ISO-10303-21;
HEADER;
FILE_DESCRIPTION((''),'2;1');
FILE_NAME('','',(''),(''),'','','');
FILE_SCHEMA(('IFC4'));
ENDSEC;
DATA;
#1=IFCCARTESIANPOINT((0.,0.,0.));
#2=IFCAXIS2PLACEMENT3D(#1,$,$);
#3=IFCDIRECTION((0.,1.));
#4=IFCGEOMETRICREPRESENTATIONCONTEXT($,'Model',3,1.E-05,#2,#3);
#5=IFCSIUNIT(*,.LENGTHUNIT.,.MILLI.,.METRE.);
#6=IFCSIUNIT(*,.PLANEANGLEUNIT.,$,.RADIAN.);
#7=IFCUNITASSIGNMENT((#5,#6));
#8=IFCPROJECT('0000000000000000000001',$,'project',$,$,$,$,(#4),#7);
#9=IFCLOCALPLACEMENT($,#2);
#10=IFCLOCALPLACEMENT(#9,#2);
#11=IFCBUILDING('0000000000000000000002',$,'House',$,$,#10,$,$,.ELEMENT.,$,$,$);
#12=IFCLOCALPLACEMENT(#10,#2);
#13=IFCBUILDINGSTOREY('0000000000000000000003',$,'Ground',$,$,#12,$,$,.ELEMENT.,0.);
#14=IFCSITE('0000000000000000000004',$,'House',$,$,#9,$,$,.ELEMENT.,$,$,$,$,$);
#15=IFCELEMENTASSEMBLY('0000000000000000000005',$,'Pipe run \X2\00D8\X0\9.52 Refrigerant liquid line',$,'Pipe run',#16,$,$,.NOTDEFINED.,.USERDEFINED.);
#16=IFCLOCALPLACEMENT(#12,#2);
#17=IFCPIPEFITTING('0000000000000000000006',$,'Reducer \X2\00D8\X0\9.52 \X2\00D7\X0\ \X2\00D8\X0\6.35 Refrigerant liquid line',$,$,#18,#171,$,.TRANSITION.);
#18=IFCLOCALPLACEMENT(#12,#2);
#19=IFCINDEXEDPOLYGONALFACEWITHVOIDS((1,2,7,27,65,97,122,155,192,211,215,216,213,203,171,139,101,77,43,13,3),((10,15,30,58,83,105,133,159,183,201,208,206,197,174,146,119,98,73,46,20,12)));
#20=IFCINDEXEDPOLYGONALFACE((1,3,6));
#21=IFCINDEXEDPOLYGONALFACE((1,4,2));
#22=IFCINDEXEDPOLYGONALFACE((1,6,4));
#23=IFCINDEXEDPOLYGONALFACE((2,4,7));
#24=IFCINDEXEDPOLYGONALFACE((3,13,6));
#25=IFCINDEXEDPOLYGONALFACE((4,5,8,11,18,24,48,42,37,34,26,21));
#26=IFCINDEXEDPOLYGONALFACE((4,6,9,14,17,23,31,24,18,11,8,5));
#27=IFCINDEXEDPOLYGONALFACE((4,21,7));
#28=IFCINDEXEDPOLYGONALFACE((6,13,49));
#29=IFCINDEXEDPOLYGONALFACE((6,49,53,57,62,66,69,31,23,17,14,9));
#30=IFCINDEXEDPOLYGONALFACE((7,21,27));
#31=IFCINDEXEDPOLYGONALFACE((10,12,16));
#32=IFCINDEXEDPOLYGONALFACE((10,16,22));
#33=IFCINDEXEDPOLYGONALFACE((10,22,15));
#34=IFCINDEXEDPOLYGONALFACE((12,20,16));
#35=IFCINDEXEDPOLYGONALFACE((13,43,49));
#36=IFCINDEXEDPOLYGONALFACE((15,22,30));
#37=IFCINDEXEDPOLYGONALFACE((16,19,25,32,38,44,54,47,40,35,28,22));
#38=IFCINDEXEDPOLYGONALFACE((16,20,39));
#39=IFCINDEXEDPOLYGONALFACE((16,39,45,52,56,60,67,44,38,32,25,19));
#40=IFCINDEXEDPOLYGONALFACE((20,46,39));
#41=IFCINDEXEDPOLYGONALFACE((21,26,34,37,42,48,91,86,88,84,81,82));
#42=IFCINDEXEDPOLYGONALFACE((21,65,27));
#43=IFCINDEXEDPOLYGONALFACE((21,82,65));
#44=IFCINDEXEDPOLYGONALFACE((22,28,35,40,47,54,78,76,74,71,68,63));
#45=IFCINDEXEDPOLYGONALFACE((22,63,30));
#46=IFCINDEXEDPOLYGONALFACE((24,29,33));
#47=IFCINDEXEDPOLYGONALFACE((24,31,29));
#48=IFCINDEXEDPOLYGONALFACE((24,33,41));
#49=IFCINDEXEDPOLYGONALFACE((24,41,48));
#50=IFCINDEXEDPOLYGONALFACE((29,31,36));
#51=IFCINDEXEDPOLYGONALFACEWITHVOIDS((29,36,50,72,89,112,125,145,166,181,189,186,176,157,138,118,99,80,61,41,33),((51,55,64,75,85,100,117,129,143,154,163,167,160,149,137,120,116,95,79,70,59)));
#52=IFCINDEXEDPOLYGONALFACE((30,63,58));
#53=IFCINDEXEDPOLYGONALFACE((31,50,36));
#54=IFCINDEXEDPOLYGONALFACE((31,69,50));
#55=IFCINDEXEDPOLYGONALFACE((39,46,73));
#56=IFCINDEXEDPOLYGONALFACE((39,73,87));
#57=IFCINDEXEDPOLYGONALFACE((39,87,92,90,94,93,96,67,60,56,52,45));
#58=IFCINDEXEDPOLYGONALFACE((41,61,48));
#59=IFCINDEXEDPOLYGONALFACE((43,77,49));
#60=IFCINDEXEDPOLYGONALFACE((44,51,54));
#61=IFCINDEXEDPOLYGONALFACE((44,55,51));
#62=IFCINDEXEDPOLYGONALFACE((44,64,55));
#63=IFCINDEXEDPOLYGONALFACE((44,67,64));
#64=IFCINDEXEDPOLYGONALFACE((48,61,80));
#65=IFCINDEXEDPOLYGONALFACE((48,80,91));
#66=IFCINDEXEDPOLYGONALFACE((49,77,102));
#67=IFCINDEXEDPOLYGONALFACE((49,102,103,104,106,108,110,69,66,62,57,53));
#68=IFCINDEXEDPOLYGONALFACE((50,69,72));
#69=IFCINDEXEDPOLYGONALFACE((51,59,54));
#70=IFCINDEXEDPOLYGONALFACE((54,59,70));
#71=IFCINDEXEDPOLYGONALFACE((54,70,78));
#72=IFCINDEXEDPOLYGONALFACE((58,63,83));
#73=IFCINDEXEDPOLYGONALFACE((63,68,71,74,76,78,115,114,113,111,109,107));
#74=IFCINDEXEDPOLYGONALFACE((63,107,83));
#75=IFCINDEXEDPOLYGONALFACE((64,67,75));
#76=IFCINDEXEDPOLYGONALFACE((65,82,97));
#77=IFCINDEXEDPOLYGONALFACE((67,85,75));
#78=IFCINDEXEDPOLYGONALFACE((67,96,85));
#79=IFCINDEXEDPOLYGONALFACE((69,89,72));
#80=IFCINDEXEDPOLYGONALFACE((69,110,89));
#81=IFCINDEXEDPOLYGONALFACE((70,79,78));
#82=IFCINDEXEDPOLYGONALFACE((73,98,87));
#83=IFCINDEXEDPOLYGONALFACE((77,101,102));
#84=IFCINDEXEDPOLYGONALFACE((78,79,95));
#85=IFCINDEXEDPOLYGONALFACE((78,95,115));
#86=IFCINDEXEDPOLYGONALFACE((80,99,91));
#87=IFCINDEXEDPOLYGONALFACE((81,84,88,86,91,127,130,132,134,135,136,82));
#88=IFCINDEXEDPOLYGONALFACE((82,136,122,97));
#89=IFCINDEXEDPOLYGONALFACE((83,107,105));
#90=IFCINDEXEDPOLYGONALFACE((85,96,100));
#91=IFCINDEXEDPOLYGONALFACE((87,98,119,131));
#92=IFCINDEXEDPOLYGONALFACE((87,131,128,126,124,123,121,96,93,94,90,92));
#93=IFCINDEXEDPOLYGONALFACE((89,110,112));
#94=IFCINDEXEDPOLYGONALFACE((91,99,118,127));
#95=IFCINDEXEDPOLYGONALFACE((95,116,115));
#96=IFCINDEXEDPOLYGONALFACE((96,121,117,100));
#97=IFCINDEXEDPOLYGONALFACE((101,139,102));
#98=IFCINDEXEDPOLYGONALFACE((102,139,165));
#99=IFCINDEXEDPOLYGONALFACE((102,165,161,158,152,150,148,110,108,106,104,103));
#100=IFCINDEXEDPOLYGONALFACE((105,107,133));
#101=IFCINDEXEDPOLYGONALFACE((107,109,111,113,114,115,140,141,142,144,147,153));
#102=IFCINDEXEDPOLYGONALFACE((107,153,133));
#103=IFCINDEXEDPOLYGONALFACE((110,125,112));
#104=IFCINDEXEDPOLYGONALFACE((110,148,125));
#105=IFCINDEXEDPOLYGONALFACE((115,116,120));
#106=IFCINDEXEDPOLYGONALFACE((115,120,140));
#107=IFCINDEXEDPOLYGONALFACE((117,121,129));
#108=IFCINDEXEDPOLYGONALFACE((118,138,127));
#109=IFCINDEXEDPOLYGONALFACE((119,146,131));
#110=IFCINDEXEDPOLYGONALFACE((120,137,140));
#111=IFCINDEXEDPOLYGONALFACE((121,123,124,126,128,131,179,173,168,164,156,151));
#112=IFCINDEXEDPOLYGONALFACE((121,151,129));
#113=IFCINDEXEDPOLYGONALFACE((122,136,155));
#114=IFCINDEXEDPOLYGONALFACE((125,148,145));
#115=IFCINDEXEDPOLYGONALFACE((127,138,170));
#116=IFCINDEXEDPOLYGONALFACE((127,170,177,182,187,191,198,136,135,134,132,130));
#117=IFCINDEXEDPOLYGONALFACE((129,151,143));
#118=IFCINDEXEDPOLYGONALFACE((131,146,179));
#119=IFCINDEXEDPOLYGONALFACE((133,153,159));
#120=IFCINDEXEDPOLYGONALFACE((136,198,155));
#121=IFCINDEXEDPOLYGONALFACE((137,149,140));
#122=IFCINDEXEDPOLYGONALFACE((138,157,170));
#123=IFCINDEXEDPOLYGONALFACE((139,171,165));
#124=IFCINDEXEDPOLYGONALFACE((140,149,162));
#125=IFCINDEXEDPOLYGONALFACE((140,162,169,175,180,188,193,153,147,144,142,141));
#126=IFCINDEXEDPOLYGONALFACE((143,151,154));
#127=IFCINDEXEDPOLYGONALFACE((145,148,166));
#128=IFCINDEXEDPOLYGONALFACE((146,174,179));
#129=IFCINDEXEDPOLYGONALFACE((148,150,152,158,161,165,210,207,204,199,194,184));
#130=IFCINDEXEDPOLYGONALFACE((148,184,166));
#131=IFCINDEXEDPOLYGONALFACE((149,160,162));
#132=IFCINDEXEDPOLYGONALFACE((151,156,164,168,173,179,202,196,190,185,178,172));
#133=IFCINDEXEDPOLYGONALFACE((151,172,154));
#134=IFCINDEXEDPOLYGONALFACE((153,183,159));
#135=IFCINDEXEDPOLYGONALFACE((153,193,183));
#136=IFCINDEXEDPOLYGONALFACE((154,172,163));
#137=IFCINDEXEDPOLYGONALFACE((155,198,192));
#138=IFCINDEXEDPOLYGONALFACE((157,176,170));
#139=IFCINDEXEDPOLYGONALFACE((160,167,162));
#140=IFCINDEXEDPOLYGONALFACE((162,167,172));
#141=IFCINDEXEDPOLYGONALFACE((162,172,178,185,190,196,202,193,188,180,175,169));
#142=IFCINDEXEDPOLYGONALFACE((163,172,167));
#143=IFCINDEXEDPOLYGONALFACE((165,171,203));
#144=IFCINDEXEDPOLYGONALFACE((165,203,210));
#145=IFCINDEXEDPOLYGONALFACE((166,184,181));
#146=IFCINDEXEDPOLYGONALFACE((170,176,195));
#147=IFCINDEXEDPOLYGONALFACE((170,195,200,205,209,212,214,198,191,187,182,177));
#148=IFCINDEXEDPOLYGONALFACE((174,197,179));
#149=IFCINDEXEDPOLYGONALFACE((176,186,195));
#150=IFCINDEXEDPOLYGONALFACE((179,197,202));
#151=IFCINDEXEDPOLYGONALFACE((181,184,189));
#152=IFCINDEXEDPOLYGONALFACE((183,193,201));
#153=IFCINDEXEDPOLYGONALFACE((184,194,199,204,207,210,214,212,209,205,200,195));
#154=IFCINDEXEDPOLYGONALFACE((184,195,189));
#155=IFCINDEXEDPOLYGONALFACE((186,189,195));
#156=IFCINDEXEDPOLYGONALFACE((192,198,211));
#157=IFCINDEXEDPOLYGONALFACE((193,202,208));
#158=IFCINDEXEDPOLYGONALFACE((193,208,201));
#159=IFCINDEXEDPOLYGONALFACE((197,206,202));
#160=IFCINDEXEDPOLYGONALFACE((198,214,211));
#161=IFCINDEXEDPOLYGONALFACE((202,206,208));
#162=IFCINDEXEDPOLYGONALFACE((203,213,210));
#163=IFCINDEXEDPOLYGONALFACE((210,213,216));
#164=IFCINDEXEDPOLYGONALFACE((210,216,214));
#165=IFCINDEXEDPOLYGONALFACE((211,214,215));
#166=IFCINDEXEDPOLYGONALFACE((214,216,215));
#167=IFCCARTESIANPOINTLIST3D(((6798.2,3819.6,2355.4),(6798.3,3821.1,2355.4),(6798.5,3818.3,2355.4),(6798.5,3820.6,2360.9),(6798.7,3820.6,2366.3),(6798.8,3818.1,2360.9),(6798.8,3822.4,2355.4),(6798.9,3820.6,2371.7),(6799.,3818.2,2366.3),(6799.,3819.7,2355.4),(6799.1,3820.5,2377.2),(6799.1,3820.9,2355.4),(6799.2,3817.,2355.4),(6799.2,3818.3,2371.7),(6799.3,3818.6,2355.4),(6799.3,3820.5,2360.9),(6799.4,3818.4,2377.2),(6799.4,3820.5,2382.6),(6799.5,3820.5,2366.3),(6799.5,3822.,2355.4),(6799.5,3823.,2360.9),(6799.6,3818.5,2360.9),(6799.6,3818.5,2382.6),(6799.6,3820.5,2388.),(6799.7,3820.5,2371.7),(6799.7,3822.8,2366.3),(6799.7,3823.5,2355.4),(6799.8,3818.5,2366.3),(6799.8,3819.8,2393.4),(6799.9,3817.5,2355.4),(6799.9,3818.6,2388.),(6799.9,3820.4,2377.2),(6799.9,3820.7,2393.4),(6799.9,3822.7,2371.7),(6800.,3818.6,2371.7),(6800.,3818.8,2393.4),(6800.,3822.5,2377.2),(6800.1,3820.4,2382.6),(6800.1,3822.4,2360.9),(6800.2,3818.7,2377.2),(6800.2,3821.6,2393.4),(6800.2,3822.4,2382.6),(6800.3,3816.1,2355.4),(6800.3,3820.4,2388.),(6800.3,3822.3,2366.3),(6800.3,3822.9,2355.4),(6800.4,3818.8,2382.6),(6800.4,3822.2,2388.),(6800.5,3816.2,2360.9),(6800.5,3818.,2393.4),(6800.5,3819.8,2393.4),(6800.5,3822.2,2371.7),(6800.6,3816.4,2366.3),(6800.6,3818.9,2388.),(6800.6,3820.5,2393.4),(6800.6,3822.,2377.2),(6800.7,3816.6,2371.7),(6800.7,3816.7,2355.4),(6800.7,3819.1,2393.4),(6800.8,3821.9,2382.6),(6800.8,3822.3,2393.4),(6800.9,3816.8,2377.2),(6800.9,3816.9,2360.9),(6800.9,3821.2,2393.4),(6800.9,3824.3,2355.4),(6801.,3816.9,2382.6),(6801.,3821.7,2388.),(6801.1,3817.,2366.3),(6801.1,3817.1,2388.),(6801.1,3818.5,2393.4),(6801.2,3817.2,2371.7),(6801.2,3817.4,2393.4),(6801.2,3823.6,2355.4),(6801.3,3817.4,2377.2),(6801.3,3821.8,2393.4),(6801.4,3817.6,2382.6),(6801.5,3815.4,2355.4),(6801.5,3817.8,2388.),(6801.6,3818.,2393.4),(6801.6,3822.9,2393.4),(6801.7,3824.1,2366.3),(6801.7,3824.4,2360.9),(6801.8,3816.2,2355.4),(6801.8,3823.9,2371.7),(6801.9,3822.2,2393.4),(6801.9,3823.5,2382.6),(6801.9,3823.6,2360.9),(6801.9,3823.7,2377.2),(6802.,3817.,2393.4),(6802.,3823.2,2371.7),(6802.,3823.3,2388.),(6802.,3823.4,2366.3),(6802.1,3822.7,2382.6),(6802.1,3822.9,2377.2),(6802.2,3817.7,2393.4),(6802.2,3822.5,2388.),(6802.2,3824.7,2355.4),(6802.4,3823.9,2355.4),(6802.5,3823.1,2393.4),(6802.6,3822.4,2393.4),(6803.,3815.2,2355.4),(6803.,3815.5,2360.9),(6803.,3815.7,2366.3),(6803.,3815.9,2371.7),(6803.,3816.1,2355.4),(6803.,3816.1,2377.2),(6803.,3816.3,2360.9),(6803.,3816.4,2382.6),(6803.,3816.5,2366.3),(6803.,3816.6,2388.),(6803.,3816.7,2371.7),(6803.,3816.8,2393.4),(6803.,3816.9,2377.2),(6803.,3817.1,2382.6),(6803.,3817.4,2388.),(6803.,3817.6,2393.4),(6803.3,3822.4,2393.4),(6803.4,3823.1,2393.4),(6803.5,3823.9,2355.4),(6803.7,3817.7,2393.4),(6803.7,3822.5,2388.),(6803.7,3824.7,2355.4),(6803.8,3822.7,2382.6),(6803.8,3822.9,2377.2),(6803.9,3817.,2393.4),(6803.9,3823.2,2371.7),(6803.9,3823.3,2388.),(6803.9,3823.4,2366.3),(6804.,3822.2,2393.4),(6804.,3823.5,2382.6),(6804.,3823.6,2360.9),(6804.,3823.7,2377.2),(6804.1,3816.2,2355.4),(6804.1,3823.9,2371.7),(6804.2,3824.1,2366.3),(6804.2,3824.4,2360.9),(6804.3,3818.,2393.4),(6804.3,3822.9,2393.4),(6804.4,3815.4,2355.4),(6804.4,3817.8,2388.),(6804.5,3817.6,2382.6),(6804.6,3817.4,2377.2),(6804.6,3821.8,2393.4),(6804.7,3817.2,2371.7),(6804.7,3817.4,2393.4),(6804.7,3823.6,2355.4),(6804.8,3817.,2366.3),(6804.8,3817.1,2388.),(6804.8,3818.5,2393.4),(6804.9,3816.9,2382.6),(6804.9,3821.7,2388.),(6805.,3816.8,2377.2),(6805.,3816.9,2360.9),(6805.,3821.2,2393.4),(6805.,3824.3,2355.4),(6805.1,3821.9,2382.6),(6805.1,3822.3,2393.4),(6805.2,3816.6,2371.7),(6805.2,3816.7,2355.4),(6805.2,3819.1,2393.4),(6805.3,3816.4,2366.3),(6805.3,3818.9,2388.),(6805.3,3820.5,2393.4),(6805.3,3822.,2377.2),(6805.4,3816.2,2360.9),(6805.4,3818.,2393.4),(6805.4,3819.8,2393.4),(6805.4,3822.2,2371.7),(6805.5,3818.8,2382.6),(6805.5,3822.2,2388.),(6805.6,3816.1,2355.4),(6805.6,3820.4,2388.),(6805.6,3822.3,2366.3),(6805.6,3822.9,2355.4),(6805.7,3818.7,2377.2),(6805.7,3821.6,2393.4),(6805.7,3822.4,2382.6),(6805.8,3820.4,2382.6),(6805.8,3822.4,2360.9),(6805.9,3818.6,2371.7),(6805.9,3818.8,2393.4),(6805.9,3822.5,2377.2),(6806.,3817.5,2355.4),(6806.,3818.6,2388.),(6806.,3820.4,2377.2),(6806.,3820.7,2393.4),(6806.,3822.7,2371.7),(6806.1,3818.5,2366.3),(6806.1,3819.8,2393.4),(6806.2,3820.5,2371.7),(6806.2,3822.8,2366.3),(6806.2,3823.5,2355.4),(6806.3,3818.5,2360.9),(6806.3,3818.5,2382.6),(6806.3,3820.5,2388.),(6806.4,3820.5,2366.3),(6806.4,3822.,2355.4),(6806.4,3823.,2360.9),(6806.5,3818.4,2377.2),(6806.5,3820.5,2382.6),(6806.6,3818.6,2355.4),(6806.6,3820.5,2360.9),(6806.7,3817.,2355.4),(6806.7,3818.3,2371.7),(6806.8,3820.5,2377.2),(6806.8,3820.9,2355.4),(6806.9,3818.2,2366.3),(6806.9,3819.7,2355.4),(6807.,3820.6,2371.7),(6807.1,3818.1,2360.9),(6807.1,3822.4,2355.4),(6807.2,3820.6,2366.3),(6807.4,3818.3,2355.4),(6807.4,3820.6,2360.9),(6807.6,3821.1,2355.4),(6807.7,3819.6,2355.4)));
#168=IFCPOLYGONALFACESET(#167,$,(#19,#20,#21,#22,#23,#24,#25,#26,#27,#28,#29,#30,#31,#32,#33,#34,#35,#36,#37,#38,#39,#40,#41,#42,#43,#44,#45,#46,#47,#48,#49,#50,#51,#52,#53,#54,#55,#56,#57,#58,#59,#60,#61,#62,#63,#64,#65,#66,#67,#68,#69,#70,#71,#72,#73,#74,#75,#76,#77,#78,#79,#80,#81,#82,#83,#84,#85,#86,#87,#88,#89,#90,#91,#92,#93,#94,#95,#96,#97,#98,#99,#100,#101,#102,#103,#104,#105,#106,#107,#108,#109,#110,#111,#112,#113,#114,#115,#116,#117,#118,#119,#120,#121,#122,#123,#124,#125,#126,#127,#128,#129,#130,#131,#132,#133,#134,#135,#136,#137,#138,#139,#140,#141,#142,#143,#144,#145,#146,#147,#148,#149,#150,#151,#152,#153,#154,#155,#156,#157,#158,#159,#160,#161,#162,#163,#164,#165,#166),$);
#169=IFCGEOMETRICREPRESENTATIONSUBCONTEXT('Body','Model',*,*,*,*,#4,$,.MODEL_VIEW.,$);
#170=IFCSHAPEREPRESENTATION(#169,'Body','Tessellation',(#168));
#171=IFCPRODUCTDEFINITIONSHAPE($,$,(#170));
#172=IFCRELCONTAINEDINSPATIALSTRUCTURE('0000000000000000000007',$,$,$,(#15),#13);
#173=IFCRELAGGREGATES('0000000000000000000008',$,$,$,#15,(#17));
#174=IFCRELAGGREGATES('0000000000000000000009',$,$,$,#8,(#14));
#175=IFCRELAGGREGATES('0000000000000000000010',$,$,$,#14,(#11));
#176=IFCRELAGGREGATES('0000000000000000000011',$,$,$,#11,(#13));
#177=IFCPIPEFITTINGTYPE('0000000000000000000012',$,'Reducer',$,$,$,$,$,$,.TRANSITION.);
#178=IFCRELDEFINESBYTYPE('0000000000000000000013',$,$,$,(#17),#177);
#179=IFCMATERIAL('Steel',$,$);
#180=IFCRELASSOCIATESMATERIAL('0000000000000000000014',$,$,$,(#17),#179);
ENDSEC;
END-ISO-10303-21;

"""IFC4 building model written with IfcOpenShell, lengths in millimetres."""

from ifc_helpers import new_model, entity, si_unit, direction, origin, origin_with_axes, place, context, subcontext, project, spatial, material, type_object, element, aggregate, save


model = new_model("IFC4")

# Units and contexts
model_context = context("Model", 3, precision=1e-05, world=origin(), true_north=direction((0.0, 1.0)))
body_context = subcontext(model_context, "Body", "Model", "MODEL_VIEW")
ifc_project = project(units=[si_unit("LENGTHUNIT", "METRE", prefix="MILLI"), si_unit("PLANEANGLEUNIT", "RADIAN")], contexts=[model_context])

# Site, building, storey
site_placement = place(None, origin())
site = spatial("IfcSite", under=ifc_project, at=site_placement, Name="House", CompositionType="ELEMENT")
building_placement = place(site_placement, origin())
building = spatial("IfcBuilding", under=site, at=building_placement, Name="House", CompositionType="ELEMENT")
storey_placement = place(building_placement, origin())
storey = spatial("IfcBuildingStorey", under=building, at=storey_placement, Name="Ground", CompositionType="ELEMENT", Elevation=0.0)

# Element assembly
assembly_1_placement = place(storey_placement, origin_with_axes())
assembly_1 = element("IfcElementAssembly", 1, at=assembly_1_placement, inside=storey, Name="Pipe run Ø9.52 Refrigerant liquid line", ObjectType="Pipe run", AssemblyPlace="NOTDEFINED", PredefinedType="USERDEFINED")
ifc_material_1 = material(Name="Steel")

# Pipe fitting
pipe_fitting_type_1 = type_object("IfcPipeFittingType", Name="Reducer", PredefinedType="TRANSITION")
pipe_fitting_1_placement = place(storey_placement, origin_with_axes())
cartesian_point_1 = entity("IfcCartesianPoint", [0.0, 3.9])
pipe_fitting_1 = element("IfcPipeFitting", 2, at=pipe_fitting_1_placement, type_object=pipe_fitting_type_1, material=ifc_material_1, Name="Reducer Ø9.52 × Ø6.35 Refrigerant liquid line", PredefinedType="TRANSITION", context=body_context, shape_type="SweptSolid", body=[
    entity("IfcRevolvedAreaSolid", entity("IfcArbitraryClosedProfileDef", "AREA", None, entity("IfcPolyline", [cartesian_point_1, entity("IfcCartesianPoint", [0.0, 4.8]), entity("IfcCartesianPoint", [38.0, 3.2]), entity("IfcCartesianPoint", [38.0, 2.4]), cartesian_point_1])), entity("IfcAxis2Placement3D", entity("IfcCartesianPoint", [6802.9, 3820.0, 2355.4]), entity("IfcDirection", [1.0, 0.0, 0.0]), entity("IfcDirection", [0.0, 0.0, 1.0])), entity("IfcAxis1Placement", entity("IfcCartesianPoint", [0.0, 0.0, 0.0]), entity("IfcDirection", [1.0, 0.0, 0.0])), 6.283185),
])
aggregate(assembly_1, [pipe_fitting_1])

save(model, "model.ifc")
